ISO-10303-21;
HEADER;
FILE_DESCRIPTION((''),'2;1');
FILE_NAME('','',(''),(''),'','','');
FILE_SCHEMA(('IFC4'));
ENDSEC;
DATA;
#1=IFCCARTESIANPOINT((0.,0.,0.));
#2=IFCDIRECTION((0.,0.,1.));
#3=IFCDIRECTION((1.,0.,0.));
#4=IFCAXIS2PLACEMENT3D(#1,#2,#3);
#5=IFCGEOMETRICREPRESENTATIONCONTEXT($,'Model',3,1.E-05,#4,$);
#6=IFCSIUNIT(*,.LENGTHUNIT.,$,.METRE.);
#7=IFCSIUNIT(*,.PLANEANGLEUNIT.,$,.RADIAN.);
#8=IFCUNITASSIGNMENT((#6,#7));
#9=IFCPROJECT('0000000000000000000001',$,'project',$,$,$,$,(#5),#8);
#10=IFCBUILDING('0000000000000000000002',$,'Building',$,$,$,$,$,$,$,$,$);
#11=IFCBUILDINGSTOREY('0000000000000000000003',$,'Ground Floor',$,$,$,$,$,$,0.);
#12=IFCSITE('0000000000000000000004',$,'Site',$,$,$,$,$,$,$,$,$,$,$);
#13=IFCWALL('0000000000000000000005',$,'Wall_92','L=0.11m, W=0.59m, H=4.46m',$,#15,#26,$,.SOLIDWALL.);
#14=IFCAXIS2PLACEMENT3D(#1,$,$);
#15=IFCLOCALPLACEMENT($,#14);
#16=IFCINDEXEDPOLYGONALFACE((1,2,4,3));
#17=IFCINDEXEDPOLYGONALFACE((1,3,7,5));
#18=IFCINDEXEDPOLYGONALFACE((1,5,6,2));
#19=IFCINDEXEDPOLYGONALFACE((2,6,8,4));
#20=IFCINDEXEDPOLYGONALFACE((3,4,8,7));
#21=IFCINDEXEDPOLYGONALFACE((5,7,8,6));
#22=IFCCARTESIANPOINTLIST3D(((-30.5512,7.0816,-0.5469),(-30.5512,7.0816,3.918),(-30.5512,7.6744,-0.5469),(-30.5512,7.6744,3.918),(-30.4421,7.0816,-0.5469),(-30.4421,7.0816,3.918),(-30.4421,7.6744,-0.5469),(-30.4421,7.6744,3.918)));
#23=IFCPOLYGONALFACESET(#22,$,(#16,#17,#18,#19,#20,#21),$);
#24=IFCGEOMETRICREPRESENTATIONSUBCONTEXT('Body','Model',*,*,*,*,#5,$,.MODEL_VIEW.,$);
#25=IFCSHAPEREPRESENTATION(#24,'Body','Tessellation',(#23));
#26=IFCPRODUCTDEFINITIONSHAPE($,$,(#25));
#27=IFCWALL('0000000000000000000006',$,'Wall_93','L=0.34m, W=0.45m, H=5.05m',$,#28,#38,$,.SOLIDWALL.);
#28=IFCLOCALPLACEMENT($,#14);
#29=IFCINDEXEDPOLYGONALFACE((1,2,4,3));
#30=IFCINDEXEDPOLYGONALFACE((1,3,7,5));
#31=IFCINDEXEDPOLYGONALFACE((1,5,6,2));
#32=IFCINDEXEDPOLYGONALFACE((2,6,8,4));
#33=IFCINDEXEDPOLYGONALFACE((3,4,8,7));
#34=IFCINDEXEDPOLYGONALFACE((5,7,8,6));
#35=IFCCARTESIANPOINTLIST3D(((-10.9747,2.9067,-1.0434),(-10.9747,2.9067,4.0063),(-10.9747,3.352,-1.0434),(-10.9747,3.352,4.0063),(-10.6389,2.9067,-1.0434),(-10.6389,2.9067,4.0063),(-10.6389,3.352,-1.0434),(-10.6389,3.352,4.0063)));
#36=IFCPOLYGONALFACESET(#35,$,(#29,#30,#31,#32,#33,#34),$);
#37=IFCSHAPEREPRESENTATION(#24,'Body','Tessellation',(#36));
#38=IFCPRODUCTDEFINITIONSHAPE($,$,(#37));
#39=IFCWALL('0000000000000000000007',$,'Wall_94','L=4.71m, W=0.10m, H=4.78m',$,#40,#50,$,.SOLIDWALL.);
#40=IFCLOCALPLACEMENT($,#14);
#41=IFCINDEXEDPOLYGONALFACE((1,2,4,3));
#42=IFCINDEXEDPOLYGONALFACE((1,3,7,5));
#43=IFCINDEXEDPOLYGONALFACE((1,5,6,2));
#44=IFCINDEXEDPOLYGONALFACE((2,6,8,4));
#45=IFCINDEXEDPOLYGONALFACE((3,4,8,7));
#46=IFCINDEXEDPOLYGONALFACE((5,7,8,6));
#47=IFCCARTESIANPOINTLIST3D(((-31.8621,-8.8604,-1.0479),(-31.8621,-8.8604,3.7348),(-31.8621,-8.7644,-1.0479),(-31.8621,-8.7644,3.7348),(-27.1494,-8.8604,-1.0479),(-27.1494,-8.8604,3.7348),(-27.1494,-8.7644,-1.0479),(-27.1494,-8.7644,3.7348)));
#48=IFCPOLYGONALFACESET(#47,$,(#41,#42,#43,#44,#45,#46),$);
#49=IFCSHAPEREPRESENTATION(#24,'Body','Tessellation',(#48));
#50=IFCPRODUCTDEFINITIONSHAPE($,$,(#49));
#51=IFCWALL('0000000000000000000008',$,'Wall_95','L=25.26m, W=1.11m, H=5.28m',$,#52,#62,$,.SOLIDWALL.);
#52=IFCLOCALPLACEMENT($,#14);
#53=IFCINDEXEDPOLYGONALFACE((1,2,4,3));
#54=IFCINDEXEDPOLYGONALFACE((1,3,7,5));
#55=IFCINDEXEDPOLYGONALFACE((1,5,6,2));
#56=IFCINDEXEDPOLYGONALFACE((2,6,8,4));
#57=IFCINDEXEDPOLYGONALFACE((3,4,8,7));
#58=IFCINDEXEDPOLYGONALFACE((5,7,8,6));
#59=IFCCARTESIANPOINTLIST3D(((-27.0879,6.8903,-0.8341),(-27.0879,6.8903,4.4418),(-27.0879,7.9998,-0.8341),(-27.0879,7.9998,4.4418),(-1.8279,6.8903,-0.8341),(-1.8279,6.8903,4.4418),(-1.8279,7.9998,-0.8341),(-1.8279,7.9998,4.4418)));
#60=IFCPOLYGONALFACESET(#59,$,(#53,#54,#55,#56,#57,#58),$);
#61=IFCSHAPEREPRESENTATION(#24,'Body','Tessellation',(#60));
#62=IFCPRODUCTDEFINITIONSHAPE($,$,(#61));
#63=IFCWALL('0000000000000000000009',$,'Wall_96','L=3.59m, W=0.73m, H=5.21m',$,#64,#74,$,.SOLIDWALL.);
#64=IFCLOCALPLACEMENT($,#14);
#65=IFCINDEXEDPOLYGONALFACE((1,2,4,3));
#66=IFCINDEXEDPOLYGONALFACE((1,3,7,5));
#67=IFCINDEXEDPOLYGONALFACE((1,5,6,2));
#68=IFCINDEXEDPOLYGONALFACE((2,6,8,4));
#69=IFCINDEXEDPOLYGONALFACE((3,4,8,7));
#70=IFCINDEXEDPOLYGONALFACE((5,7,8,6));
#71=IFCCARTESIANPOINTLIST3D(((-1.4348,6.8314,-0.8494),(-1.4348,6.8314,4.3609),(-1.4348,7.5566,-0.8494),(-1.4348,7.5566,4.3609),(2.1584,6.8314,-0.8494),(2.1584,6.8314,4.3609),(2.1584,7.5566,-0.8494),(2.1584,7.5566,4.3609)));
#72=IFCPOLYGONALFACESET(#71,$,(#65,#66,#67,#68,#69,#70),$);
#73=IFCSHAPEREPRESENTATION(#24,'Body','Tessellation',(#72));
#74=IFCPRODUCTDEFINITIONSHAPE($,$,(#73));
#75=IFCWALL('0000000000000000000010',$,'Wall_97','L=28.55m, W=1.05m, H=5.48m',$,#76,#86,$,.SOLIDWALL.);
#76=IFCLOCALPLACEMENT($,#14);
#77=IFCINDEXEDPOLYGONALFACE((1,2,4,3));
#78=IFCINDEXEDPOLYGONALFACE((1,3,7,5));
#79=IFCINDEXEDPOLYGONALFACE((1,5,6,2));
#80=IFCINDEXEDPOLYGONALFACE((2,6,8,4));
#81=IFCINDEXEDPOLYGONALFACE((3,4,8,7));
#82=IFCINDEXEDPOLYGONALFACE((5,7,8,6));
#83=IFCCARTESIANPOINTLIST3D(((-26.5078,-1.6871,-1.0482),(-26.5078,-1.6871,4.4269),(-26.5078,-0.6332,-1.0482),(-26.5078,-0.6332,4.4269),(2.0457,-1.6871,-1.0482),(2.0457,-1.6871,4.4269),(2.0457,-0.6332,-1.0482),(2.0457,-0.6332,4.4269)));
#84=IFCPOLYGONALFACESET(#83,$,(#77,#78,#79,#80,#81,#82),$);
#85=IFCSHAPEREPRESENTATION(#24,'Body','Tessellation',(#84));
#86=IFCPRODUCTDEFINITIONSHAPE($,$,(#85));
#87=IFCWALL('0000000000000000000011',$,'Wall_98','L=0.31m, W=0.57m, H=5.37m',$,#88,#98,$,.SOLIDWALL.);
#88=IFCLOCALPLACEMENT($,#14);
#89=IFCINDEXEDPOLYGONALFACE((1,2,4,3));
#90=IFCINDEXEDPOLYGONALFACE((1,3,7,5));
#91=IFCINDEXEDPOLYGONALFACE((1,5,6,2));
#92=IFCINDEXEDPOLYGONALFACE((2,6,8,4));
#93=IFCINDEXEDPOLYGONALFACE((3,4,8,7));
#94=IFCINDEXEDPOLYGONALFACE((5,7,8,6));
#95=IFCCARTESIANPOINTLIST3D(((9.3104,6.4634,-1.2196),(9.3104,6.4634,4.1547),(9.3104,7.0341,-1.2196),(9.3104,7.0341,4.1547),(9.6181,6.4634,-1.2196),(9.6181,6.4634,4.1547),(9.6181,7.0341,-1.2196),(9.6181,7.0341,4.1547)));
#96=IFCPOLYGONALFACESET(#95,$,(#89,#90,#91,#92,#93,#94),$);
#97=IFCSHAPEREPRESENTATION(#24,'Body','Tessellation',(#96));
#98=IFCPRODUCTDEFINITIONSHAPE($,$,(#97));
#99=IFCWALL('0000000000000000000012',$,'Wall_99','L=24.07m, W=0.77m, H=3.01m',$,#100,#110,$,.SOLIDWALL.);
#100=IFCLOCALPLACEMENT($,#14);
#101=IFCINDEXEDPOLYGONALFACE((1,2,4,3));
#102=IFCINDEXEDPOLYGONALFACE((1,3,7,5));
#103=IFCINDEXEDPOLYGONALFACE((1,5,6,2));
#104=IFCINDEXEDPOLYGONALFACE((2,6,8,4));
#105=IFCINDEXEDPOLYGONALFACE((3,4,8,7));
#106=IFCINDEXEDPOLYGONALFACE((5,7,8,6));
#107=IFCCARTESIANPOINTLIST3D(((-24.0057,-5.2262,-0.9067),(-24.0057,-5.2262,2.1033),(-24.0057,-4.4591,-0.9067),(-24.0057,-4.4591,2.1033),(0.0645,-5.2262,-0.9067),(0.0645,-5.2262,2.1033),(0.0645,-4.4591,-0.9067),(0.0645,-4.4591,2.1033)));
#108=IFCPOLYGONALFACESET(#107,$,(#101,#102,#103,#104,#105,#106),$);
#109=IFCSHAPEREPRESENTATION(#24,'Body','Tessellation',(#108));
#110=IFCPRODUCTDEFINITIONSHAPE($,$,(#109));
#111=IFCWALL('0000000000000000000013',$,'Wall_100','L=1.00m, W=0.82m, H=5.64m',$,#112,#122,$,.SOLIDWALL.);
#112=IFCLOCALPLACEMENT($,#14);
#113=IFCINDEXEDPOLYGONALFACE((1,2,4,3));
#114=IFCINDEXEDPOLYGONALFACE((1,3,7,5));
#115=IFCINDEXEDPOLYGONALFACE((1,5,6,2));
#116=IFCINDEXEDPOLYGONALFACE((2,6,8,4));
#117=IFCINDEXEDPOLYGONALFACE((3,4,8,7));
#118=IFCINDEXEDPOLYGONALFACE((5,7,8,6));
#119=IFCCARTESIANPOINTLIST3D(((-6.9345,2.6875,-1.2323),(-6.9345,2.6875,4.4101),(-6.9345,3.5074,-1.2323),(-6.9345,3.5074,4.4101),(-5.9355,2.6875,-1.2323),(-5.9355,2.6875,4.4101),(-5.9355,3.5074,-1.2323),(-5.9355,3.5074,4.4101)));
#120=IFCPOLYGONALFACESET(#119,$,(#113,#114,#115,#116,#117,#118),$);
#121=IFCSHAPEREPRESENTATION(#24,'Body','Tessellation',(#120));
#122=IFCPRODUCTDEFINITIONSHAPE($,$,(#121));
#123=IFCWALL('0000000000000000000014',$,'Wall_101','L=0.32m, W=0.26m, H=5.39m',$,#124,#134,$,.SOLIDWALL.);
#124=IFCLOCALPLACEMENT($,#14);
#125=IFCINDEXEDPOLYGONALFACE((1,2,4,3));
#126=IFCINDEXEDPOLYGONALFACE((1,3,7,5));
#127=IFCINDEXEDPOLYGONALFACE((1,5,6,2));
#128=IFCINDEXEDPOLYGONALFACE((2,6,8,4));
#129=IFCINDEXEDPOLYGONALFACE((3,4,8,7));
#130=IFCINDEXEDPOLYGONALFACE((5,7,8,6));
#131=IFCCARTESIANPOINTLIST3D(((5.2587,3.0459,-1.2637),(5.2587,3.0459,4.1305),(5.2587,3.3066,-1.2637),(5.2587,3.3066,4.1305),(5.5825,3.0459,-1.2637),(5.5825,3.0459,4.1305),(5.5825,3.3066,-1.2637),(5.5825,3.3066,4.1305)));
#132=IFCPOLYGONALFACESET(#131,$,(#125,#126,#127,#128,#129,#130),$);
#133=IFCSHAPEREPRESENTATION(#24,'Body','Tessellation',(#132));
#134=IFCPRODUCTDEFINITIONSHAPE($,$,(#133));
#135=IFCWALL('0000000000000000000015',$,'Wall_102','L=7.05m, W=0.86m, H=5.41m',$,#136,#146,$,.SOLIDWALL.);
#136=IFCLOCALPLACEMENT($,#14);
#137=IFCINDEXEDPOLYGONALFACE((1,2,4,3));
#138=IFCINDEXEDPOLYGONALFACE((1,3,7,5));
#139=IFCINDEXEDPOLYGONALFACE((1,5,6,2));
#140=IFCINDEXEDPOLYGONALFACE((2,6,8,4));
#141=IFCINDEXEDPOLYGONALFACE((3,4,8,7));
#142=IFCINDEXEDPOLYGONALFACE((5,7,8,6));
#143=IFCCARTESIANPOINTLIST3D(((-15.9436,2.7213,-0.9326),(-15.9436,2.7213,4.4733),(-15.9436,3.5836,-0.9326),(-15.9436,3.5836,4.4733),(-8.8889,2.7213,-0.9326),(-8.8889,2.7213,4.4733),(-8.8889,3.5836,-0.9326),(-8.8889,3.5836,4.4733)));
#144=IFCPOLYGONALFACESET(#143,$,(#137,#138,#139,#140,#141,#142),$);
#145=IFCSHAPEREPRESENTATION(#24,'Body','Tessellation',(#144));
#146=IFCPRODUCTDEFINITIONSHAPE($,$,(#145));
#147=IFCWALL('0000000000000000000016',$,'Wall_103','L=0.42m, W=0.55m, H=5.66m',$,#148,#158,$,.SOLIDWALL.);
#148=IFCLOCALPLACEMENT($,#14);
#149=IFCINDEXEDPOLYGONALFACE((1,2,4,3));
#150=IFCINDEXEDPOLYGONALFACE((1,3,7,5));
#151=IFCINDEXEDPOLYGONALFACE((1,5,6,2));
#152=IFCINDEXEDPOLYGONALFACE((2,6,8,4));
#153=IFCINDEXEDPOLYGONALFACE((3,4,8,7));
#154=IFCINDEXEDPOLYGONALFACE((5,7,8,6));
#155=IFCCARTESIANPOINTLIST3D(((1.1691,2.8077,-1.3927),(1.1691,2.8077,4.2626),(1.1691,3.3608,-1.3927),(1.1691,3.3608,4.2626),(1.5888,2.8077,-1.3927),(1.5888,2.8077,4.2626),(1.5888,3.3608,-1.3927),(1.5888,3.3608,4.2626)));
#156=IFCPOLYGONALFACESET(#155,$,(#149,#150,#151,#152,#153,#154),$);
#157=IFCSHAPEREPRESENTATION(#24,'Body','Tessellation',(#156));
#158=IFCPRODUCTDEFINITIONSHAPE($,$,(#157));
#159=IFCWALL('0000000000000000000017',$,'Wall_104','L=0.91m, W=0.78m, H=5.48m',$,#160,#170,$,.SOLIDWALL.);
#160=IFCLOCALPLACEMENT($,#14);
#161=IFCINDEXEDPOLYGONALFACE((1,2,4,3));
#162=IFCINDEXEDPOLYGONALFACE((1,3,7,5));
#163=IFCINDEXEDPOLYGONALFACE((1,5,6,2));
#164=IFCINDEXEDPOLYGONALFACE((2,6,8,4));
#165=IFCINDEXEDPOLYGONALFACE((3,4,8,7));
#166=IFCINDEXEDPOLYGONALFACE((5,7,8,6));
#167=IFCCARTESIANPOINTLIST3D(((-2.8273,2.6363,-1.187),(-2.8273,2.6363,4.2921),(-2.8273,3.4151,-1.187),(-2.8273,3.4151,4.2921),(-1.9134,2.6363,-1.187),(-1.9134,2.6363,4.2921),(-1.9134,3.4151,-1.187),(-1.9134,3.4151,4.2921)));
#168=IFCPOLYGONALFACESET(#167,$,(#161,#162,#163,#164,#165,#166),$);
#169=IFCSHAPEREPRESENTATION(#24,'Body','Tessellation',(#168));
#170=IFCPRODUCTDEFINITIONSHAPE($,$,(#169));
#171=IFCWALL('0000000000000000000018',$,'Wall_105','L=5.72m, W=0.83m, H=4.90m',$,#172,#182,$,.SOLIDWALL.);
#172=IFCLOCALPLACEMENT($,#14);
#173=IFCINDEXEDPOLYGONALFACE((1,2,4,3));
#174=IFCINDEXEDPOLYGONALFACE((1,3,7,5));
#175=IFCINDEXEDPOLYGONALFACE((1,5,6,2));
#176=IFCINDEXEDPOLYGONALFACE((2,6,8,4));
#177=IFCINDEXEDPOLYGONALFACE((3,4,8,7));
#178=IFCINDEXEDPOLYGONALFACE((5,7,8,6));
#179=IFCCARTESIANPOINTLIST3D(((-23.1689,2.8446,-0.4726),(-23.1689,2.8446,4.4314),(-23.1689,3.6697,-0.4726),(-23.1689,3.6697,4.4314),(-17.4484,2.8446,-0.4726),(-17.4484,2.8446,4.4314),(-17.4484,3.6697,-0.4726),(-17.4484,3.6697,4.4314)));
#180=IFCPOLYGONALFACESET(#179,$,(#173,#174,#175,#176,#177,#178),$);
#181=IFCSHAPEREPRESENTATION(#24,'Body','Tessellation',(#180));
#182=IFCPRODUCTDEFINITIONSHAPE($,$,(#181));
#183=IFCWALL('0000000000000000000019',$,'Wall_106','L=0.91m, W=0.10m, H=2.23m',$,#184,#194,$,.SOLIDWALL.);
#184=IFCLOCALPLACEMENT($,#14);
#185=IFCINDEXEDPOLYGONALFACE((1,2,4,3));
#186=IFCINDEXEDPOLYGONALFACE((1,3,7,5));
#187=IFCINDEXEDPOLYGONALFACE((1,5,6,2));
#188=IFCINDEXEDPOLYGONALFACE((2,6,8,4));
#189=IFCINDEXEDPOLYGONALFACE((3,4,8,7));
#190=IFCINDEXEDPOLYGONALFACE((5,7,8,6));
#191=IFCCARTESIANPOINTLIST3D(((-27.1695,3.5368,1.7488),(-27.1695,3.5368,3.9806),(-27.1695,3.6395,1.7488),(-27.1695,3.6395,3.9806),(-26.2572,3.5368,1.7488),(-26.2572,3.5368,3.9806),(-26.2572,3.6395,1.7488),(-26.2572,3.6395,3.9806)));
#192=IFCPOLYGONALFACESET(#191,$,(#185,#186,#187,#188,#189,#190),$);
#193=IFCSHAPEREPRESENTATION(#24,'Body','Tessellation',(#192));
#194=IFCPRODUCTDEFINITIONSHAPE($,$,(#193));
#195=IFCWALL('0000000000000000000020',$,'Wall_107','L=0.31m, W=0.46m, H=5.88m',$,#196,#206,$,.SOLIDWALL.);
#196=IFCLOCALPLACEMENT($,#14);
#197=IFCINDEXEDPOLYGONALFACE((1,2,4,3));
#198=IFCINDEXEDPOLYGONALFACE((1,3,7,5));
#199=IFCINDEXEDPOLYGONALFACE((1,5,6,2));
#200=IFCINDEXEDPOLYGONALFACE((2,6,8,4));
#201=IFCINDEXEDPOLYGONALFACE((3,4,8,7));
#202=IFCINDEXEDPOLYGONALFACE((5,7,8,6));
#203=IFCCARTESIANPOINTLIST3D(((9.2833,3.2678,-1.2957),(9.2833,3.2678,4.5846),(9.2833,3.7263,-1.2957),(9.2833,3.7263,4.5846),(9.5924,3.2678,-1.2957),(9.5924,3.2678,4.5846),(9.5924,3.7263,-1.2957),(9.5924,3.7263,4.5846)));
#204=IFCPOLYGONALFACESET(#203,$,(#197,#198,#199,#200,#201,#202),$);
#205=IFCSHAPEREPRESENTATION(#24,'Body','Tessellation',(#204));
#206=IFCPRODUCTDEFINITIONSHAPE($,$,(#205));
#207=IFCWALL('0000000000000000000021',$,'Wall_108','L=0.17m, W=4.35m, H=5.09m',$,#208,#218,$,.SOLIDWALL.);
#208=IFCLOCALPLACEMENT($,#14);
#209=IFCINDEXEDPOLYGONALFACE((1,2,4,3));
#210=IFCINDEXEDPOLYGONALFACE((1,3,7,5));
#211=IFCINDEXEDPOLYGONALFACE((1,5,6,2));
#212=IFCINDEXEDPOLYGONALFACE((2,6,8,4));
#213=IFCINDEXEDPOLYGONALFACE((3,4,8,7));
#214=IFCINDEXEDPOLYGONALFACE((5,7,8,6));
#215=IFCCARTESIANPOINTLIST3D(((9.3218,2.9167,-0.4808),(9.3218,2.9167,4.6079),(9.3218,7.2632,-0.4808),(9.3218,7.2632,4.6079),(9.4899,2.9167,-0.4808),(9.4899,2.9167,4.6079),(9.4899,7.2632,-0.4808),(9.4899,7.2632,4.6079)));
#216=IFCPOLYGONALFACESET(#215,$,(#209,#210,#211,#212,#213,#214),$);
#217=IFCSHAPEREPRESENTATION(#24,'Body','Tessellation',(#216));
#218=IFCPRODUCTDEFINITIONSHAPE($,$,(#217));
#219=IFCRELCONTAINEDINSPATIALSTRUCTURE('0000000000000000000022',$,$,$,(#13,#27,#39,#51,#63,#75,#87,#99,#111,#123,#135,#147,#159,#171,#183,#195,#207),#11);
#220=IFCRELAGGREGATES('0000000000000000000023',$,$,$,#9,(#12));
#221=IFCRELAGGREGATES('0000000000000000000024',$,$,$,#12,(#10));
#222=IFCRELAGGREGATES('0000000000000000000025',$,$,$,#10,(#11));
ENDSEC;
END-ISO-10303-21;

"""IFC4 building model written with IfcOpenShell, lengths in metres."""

from ifc_helpers import new_model, si_unit, frame, origin_with_axes, origin_2d, context, subcontext, project, spatial, rectangle, extrude, element, save


model = new_model("IFC4")

# Units and contexts
model_context = context("Model", 3, precision=1e-05, world=origin_with_axes())
body_context = subcontext(model_context, "Body", "Model", "MODEL_VIEW")
ifc_project = project(units=[si_unit("LENGTHUNIT", "METRE"), si_unit("PLANEANGLEUNIT", "RADIAN")], contexts=[model_context])

# Site, building, storey
site = spatial("IfcSite", under=ifc_project, Name="Site")
building = spatial("IfcBuilding", under=site, Name="Building")
storey = spatial("IfcBuildingStorey", under=building, Name="Ground Floor", Elevation=0.0)

# Walls
element("IfcWall", 1, inside=storey, Name="Wall_92", Description="L=0.11m, W=0.59m, H=4.46m", PredefinedType="SOLIDWALL", context=body_context, shape_type="SweptSolid", body=[
    extrude(rectangle(XDim=0.1091, YDim=0.5928, at=origin_2d()), frame((-30.4967, 7.378, -0.5469), z_axis=(0.0, 0.0, 1.0), x_axis=(1.0, 0.0, 0.0)), (0.0, 0.0, 1.0), 4.4649),
])
element("IfcWall", 2, inside=storey, Name="Wall_93", Description="L=0.34m, W=0.45m, H=5.05m", PredefinedType="SOLIDWALL", context=body_context, shape_type="SweptSolid", body=[
    extrude(rectangle(XDim=0.3358, YDim=0.4454, at=origin_2d()), frame((-10.8068, 3.1293, -1.0434), z_axis=(0.0, 0.0, 1.0), x_axis=(1.0, 0.0, 0.0)), (0.0, 0.0, 1.0), 5.0497),
])
element("IfcWall", 3, inside=storey, Name="Wall_94", Description="L=4.71m, W=0.10m, H=4.78m", PredefinedType="SOLIDWALL", context=body_context, shape_type="SweptSolid", body=[
    extrude(rectangle(XDim=4.7127, YDim=0.0959, at=origin_2d()), frame((-29.5058, -8.8124, -1.0479), z_axis=(0.0, 0.0, 1.0), x_axis=(1.0, 0.0, 0.0)), (0.0, 0.0, 1.0), 4.7827),
])
element("IfcWall", 4, inside=storey, Name="Wall_95", Description="L=25.26m, W=1.11m, H=5.28m", PredefinedType="SOLIDWALL", context=body_context, shape_type="SweptSolid", body=[
    extrude(rectangle(XDim=25.26, YDim=1.1095, at=origin_2d()), frame((-14.4579, 7.4451, -0.8341), z_axis=(0.0, 0.0, 1.0), x_axis=(1.0, 0.0, 0.0)), (0.0, 0.0, 1.0), 5.276),
])
element("IfcWall", 5, inside=storey, Name="Wall_96", Description="L=3.59m, W=0.73m, H=5.21m", PredefinedType="SOLIDWALL", context=body_context, shape_type="SweptSolid", body=[
    extrude(rectangle(XDim=3.5931, YDim=0.7253, at=origin_2d()), frame((0.3618, 7.194, -0.8494), z_axis=(0.0, 0.0, 1.0), x_axis=(1.0, 0.0, 0.0)), (0.0, 0.0, 1.0), 5.2103),
])
element("IfcWall", 6, inside=storey, Name="Wall_97", Description="L=28.55m, W=1.05m, H=5.48m", PredefinedType="SOLIDWALL", context=body_context, shape_type="SweptSolid", body=[
    extrude(rectangle(XDim=28.5534, YDim=1.0539, at=origin_2d()), frame((-12.231, -1.1601, -1.0482), z_axis=(0.0, 0.0, 1.0), x_axis=(1.0, 0.0, 0.0)), (0.0, 0.0, 1.0), 5.4752),
])
element("IfcWall", 7, inside=storey, Name="Wall_98", Description="L=0.31m, W=0.57m, H=5.37m", PredefinedType="SOLIDWALL", context=body_context, shape_type="SweptSolid", body=[
    extrude(rectangle(XDim=0.3077, YDim=0.5707, at=origin_2d()), frame((9.4642, 6.7487, -1.2196), z_axis=(0.0, 0.0, 1.0), x_axis=(1.0, 0.0, 0.0)), (0.0, 0.0, 1.0), 5.3743),
])
element("IfcWall", 8, inside=storey, Name="Wall_99", Description="L=24.07m, W=0.77m, H=3.01m", PredefinedType="SOLIDWALL", context=body_context, shape_type="SweptSolid", body=[
    extrude(rectangle(XDim=24.0702, YDim=0.7671, at=origin_2d()), frame((-11.9706, -4.8426, -0.9067), z_axis=(0.0, 0.0, 1.0), x_axis=(1.0, 0.0, 0.0)), (0.0, 0.0, 1.0), 3.01),
])
element("IfcWall", 9, inside=storey, Name="Wall_100", Description="L=1.00m, W=0.82m, H=5.64m", PredefinedType="SOLIDWALL", context=body_context, shape_type="SweptSolid", body=[
    extrude(rectangle(XDim=0.999, YDim=0.8198, at=origin_2d()), frame((-6.435, 3.0974, -1.2323), z_axis=(0.0, 0.0, 1.0), x_axis=(1.0, 0.0, 0.0)), (0.0, 0.0, 1.0), 5.6424),
])
element("IfcWall", 10, inside=storey, Name="Wall_101", Description="L=0.32m, W=0.26m, H=5.39m", PredefinedType="SOLIDWALL", context=body_context, shape_type="SweptSolid", body=[
    extrude(rectangle(XDim=0.3237, YDim=0.2606, at=origin_2d()), frame((5.4206, 3.1763, -1.2637), z_axis=(0.0, 0.0, 1.0), x_axis=(1.0, 0.0, 0.0)), (0.0, 0.0, 1.0), 5.3941),
])
element("IfcWall", 11, inside=storey, Name="Wall_102", Description="L=7.05m, W=0.86m, H=5.41m", PredefinedType="SOLIDWALL", context=body_context, shape_type="SweptSolid", body=[
    extrude(rectangle(XDim=7.0547, YDim=0.8623, at=origin_2d()), frame((-12.4163, 3.1524, -0.9326), z_axis=(0.0, 0.0, 1.0), x_axis=(1.0, 0.0, 0.0)), (0.0, 0.0, 1.0), 5.4059),
])
element("IfcWall", 12, inside=storey, Name="Wall_103", Description="L=0.42m, W=0.55m, H=5.66m", PredefinedType="SOLIDWALL", context=body_context, shape_type="SweptSolid", body=[
    extrude(rectangle(XDim=0.4197, YDim=0.5531, at=origin_2d()), frame((1.379, 3.0842, -1.3927), z_axis=(0.0, 0.0, 1.0), x_axis=(1.0, 0.0, 0.0)), (0.0, 0.0, 1.0), 5.6553),
])
element("IfcWall", 13, inside=storey, Name="Wall_104", Description="L=0.91m, W=0.78m, H=5.48m", PredefinedType="SOLIDWALL", context=body_context, shape_type="SweptSolid", body=[
    extrude(rectangle(XDim=0.9138, YDim=0.7788, at=origin_2d()), frame((-2.3703, 3.0257, -1.187), z_axis=(0.0, 0.0, 1.0), x_axis=(1.0, 0.0, 0.0)), (0.0, 0.0, 1.0), 5.4791),
])
element("IfcWall", 14, inside=storey, Name="Wall_105", Description="L=5.72m, W=0.83m, H=4.90m", PredefinedType="SOLIDWALL", context=body_context, shape_type="SweptSolid", body=[
    extrude(rectangle(XDim=5.7205, YDim=0.8251, at=origin_2d()), frame((-20.3086, 3.2571, -0.4726), z_axis=(0.0, 0.0, 1.0), x_axis=(1.0, 0.0, 0.0)), (0.0, 0.0, 1.0), 4.9039),
])
element("IfcWall", 15, inside=storey, Name="Wall_106", Description="L=0.91m, W=0.10m, H=2.23m", PredefinedType="SOLIDWALL", context=body_context, shape_type="SweptSolid", body=[
    extrude(rectangle(XDim=0.9124, YDim=0.1028, at=origin_2d()), frame((-26.7134, 3.5881, 1.7488), z_axis=(0.0, 0.0, 1.0), x_axis=(1.0, 0.0, 0.0)), (0.0, 0.0, 1.0), 2.2317),
])
element("IfcWall", 16, inside=storey, Name="Wall_107", Description="L=0.31m, W=0.46m, H=5.88m", PredefinedType="SOLIDWALL", context=body_context, shape_type="SweptSolid", body=[
    extrude(rectangle(XDim=0.3092, YDim=0.4585, at=origin_2d()), frame((9.4379, 3.497, -1.2957), z_axis=(0.0, 0.0, 1.0), x_axis=(1.0, 0.0, 0.0)), (0.0, 0.0, 1.0), 5.8803),
])
element("IfcWall", 17, inside=storey, Name="Wall_108", Description="L=0.17m, W=4.35m, H=5.09m", PredefinedType="SOLIDWALL", context=body_context, shape_type="SweptSolid", body=[
    extrude(rectangle(XDim=0.1681, YDim=4.3465, at=origin_2d()), frame((9.4059, 5.09, -0.4808), z_axis=(0.0, 0.0, 1.0), x_axis=(1.0, 0.0, 0.0)), (0.0, 0.0, 1.0), 5.0886),
])

save(model, "model.ifc")
